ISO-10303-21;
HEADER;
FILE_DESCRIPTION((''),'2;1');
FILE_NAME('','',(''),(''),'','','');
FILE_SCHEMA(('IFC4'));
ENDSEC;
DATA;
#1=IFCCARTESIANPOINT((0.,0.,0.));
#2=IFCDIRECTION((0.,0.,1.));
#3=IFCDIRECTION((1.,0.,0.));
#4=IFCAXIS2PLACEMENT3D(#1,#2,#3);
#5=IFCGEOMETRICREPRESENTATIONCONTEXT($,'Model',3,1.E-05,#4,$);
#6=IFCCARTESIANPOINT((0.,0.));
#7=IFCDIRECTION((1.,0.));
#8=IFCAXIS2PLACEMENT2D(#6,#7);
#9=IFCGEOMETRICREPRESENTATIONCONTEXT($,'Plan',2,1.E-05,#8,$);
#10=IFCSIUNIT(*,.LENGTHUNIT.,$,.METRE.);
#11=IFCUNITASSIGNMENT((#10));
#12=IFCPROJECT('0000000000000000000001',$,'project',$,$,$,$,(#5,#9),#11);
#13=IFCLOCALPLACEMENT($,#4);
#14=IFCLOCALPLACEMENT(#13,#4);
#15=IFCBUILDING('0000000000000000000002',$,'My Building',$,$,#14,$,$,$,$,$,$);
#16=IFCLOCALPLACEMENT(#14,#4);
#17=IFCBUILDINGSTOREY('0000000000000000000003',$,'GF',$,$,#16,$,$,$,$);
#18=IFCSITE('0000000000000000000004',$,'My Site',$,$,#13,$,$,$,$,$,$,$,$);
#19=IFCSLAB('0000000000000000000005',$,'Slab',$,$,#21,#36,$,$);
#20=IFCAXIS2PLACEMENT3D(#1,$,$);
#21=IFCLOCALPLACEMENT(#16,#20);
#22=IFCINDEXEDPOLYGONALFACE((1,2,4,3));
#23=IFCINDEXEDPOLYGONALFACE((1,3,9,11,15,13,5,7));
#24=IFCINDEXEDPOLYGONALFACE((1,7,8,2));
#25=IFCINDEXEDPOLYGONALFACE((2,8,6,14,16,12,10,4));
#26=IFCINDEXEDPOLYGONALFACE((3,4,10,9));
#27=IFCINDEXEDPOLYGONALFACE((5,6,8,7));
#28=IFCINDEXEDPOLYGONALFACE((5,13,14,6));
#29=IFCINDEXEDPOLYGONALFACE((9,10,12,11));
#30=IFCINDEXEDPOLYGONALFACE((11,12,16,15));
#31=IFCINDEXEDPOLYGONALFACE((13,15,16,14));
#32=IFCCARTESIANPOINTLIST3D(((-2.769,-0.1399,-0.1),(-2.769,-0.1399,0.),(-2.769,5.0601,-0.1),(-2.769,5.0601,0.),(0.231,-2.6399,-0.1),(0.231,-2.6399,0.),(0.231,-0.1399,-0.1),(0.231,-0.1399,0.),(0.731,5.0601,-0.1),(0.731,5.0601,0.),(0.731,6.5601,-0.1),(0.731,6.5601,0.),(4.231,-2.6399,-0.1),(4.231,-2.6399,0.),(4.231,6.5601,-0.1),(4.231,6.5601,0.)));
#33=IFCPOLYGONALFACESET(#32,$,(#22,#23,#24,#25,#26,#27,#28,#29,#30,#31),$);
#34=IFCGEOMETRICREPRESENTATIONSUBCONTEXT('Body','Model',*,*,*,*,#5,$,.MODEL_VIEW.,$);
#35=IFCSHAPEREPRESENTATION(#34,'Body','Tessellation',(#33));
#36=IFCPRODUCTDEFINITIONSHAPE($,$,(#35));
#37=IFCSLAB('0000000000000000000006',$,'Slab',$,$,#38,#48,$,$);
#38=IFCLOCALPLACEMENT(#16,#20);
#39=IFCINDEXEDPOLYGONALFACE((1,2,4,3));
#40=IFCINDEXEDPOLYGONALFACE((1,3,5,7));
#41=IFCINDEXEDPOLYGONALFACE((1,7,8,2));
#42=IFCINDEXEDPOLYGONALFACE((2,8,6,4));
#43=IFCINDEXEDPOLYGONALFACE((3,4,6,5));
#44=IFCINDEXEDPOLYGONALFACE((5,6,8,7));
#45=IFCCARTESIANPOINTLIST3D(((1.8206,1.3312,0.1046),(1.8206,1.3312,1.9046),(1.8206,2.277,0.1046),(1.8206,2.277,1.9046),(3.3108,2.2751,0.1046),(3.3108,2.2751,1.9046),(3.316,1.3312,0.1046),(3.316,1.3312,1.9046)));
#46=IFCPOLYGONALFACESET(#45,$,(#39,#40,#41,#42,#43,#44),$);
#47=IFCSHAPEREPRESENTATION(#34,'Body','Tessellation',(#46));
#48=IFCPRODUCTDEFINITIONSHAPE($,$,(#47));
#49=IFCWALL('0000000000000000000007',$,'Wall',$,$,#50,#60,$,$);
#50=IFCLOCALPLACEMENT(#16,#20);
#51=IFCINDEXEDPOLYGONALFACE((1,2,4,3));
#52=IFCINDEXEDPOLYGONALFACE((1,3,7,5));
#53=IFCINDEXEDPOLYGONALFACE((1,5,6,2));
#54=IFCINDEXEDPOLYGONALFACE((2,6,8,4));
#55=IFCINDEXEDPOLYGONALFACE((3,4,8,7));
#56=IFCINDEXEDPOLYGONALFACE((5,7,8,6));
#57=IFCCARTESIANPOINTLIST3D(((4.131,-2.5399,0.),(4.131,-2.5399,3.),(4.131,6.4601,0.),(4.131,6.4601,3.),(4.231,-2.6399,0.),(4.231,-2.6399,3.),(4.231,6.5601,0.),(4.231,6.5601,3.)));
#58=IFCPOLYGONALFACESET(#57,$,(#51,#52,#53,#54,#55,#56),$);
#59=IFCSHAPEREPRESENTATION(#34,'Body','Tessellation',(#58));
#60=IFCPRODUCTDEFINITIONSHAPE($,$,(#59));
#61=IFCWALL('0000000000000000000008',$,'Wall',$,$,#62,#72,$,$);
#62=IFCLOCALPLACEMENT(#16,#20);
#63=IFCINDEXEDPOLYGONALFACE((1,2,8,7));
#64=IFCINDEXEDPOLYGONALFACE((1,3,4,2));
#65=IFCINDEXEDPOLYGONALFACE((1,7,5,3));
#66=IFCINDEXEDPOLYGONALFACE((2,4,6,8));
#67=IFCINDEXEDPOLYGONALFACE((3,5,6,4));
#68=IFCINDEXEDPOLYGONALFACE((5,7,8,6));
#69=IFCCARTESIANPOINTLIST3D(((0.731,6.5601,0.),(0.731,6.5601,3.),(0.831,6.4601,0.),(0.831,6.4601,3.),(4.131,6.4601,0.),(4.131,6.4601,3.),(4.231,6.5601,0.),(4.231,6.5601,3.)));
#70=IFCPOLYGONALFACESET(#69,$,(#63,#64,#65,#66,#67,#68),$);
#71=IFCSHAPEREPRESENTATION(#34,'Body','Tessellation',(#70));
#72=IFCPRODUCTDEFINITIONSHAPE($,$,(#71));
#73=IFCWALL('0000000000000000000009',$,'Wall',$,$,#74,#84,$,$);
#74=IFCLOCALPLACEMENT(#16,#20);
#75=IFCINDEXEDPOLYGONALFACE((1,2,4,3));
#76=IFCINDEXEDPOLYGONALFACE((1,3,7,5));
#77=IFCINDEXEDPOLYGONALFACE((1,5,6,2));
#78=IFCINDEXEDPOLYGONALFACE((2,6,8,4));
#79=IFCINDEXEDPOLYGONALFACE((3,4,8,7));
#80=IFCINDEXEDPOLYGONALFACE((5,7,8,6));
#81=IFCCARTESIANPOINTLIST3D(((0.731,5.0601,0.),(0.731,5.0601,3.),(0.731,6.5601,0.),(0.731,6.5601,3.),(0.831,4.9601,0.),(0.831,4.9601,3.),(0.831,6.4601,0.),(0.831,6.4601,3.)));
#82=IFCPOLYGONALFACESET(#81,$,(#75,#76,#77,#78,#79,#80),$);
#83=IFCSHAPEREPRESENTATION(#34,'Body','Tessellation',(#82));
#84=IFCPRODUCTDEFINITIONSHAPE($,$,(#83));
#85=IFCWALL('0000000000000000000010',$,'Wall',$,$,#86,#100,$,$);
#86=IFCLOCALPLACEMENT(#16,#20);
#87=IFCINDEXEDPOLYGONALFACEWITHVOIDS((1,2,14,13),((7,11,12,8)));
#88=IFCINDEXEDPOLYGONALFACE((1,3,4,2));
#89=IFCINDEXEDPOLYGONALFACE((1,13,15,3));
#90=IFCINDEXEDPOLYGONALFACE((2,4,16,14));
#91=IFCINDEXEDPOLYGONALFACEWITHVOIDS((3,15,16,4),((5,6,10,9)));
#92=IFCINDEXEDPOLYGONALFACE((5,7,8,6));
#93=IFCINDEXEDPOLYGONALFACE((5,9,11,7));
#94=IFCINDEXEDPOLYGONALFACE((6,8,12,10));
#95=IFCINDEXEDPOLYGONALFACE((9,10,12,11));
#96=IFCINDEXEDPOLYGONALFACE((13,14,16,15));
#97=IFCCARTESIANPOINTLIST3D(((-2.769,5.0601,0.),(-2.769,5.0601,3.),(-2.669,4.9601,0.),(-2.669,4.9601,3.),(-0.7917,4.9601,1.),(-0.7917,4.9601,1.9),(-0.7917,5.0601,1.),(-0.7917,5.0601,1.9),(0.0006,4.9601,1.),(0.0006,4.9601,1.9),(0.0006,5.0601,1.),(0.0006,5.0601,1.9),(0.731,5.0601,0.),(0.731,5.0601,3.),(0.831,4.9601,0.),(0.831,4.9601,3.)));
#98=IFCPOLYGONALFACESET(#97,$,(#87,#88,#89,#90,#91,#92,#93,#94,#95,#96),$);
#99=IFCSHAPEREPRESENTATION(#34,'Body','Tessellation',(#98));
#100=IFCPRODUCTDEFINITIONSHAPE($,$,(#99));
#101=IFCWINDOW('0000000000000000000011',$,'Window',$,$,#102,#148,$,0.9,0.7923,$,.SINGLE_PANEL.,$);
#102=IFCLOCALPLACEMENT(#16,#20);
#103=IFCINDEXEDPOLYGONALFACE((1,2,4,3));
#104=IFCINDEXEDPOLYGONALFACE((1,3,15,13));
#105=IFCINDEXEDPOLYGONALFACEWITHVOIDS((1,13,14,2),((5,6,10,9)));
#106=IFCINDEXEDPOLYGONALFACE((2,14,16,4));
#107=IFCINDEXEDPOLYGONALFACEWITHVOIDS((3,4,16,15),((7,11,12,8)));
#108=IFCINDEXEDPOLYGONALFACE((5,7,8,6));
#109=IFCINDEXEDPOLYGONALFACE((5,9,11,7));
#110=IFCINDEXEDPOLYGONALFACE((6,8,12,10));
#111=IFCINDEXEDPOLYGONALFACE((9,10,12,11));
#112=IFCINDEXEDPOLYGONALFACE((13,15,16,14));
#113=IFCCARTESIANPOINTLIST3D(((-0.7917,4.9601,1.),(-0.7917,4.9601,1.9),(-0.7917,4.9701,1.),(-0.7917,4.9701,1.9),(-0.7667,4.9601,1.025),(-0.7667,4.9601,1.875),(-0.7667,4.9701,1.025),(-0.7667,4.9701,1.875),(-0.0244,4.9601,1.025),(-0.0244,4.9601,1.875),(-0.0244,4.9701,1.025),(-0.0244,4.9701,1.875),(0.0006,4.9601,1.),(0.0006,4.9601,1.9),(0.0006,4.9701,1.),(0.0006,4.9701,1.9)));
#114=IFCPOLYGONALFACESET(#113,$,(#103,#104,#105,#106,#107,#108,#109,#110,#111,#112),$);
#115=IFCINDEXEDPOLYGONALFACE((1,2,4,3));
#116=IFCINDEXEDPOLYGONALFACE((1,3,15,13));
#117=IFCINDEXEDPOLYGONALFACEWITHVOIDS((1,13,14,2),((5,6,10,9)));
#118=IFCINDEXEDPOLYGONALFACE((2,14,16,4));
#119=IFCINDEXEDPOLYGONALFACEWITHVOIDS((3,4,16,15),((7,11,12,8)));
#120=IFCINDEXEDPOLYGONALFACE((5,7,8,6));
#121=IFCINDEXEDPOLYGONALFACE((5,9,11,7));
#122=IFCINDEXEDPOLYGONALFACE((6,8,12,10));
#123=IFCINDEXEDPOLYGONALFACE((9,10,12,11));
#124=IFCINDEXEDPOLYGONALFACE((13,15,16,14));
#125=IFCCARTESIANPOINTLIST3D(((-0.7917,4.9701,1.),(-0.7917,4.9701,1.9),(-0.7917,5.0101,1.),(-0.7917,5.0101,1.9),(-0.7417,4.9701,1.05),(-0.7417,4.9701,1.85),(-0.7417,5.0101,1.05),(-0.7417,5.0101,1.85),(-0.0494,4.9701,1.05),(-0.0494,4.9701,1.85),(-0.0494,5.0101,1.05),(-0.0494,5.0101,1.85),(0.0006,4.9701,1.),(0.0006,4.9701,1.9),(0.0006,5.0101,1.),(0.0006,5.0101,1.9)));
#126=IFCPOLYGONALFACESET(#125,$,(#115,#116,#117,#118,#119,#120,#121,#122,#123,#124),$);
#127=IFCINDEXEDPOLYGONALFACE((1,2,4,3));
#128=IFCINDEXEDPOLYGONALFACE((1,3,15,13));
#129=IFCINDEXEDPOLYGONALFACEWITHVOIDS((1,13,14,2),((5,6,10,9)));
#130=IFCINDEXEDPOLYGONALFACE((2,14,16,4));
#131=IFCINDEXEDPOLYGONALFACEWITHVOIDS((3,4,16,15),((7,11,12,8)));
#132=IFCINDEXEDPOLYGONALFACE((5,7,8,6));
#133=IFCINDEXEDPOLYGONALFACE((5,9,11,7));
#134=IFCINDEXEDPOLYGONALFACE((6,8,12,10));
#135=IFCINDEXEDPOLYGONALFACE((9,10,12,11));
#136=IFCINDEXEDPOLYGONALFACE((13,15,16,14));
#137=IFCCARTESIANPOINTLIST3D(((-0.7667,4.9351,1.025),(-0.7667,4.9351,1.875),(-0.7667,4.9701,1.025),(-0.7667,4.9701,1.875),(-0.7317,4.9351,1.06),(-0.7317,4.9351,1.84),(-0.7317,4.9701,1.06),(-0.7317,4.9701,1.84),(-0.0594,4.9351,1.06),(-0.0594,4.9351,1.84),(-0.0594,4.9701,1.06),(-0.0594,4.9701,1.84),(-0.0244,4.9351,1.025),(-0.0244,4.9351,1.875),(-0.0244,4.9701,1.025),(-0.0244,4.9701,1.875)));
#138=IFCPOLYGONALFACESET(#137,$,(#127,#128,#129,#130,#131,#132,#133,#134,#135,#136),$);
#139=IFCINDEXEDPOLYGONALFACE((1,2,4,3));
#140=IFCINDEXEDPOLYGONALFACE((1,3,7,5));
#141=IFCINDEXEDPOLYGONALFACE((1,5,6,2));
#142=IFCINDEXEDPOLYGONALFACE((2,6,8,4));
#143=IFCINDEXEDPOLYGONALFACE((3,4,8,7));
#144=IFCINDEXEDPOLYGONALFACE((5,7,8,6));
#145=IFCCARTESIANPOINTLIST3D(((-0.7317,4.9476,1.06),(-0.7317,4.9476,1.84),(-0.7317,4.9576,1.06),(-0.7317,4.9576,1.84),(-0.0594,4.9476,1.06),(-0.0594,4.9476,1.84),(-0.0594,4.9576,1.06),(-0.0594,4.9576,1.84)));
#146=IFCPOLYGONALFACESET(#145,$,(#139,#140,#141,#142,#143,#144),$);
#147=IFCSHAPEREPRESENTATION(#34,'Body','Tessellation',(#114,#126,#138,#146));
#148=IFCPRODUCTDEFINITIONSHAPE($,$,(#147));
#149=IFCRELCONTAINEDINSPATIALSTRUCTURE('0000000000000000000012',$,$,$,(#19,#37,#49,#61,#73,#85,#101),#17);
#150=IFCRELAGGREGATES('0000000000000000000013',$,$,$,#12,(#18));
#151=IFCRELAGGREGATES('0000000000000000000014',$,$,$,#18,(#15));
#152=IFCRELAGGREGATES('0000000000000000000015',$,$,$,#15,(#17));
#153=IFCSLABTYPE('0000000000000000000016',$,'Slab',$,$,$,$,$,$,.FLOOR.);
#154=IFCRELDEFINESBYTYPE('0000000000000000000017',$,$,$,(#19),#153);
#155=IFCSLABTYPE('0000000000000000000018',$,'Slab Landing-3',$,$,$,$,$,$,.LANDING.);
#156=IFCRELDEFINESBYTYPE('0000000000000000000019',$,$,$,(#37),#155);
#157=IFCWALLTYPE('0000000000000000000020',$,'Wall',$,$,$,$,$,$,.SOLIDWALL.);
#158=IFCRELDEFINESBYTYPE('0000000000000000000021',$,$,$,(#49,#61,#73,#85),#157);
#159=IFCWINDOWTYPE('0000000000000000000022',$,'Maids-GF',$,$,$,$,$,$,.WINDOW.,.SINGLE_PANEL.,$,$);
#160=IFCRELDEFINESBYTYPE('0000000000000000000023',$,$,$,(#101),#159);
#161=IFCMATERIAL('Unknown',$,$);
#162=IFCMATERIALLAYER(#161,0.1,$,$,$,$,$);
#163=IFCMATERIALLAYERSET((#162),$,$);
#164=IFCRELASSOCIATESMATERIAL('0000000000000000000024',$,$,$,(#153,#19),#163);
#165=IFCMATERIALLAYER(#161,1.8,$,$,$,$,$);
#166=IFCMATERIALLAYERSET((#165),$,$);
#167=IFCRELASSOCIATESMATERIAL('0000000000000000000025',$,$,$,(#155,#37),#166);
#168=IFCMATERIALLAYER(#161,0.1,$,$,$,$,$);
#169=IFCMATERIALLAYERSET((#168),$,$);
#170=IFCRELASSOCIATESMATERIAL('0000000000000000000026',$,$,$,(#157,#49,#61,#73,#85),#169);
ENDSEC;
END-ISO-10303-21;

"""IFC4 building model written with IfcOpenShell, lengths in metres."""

from ifc_helpers import new_model, entity, si_unit, frame, origin_with_axes, origin_2d_with_axis, place, context, subcontext, project, spatial, line, indexed_curve, outline, extrude, shape, source, transform, mapped, material, layer, layer_set, layer_usage, type_object, type_shapes, element, fill, save


model = new_model("IFC4")

# Units and contexts
model_context = context("Model", 3, precision=1e-05, world=origin_with_axes())
plan_context = context("Plan", 2, precision=1e-05, world=origin_2d_with_axis())
body_context_1 = subcontext(model_context, "Body", "Model", "MODEL_VIEW")
body_context_2 = subcontext(plan_context, "Body", "Plan", "PLAN_VIEW")
ifc_project = project(units=[si_unit("LENGTHUNIT", "METRE")], contexts=[model_context, plan_context])

# Site, building, storey
site_placement = place(None, origin_with_axes())
site = spatial("IfcSite", under=ifc_project, at=site_placement, Name="My Site")
building_placement = place(site_placement, origin_with_axes())
building = spatial("IfcBuilding", under=site, at=building_placement, Name="My Building")
storey_placement = place(building_placement, origin_with_axes())
storey = spatial("IfcBuildingStorey", under=building, at=storey_placement, Name="GF")

# Slabs
ifc_material_1 = material(Name="Unknown")
ifc_layer_1 = layer(ifc_material_1, 0.1)
ifc_layer_set_1 = layer_set([ifc_layer_1])
ifc_layer_usage_1 = layer_usage(ifc_layer_set_1, "AXIS3", "POSITIVE", -0.1)
slab_type_1 = type_object("IfcSlabType", Name="Slab", PredefinedType="FLOOR", material=ifc_layer_set_1)
slab_1_placement = place(storey_placement, frame((4.231, 6.5601, 0.0), z_axis=(0.0, 0.0, 1.0), x_axis=(1.0, 0.0, 0.0)))
element("IfcSlab", 1, at=slab_1_placement, inside=storey, type_object=slab_type_1, material=ifc_layer_usage_1, Name="Slab", context=body_context_1, shape_type="SweptSolid", body=[
    extrude(outline(indexed_curve([(0.0, 0.0), (-3.5, 0.0), (-3.5, -1.5), (-7.0, -1.5), (-7.0, -6.7), (-4.0, -6.7), (-4.0, -9.2), (0.0, -9.2), (0.0, 0.0)])), frame((0.0, 0.0, -0.1), z_axis=(0.0, 0.0, 1.0), x_axis=(1.0, 0.0, 0.0)), (0.0, 0.0, 1.0), 0.1),
])
ifc_layer_2 = layer(ifc_material_1, 1.8)
ifc_layer_set_2 = layer_set([ifc_layer_2])
ifc_layer_usage_2 = layer_usage(ifc_layer_set_2, "AXIS3", "POSITIVE", -1.8)
slab_type_2 = type_object("IfcSlabType", Name="Slab Landing-3", PredefinedType="LANDING", material=ifc_layer_set_2)
slab_2_placement = place(storey_placement, frame((3.3108, 2.2751, 1.9046), z_axis=(0.0, 0.0, 1.0), x_axis=(1.0, 0.0, 0.0)))
element("IfcSlab", 2, at=slab_2_placement, inside=storey, type_object=slab_type_2, material=ifc_layer_usage_2, Name="Slab", context=body_context_1, shape_type="SweptSolid", body=[
    extrude(outline(indexed_curve([(0.0, 0.0), (0.0053, -0.9439), (-1.4901, -0.9439), (-1.4902, 0.0019), (0.0, 0.0)])), frame((0.0, 0.0, -1.8), z_axis=(0.0, 0.0, 1.0), x_axis=(1.0, 0.0, 0.0)), (0.0, 0.0, 1.0), 1.8),
])

# Shared definitions
ifc_layer_3 = layer(ifc_material_1, 0.1)
ifc_layer_set_3 = layer_set([ifc_layer_3])
wall_type = type_object("IfcWallType", Name="Wall", PredefinedType="SOLIDWALL", material=ifc_layer_set_3)

# Walls
ifc_layer_usage_3 = layer_usage(ifc_layer_set_3, "AXIS2", "POSITIVE", 0.0)
wall_1_placement = place(storey_placement, frame((4.231, -2.6399, 0.0), z_axis=(0.0, 0.0, 1.0), x_axis=(0.0, 1.0, 0.0)))
element("IfcWall", 3, at=wall_1_placement, inside=storey, type_object=wall_type, material=ifc_layer_usage_3, Name="Wall", context=body_context_1, shape_type="SweptSolid", body=[
    extrude(outline(indexed_curve([(0.0, 0.0), (0.1, 0.1), (9.1, 0.1), (9.2, 0.0)], segments=[line(1, 2, 3, 4, 1)])), origin_with_axes(), (0.0, 0.0, 1.0), 3.0),
])
ifc_layer_usage_4 = layer_usage(ifc_layer_set_3, "AXIS2", "POSITIVE", 0.0)
wall_2_placement = place(storey_placement, frame((4.231, 6.5601, 0.0), z_axis=(0.0, 0.0, 1.0), x_axis=(-1.0, 0.0, 0.0)))
element("IfcWall", 4, at=wall_2_placement, inside=storey, type_object=wall_type, material=ifc_layer_usage_4, Name="Wall", context=body_context_1, shape_type="SweptSolid", body=[
    extrude(outline(indexed_curve([(0.0, 0.0), (0.1, 0.1), (3.4, 0.1), (3.5, 0.0)], segments=[line(1, 2, 3, 4, 1)])), origin_with_axes(), (0.0, 0.0, 1.0), 3.0),
])
ifc_layer_usage_5 = layer_usage(ifc_layer_set_3, "AXIS2", "POSITIVE", 0.0)
wall_3_placement = place(storey_placement, frame((0.731, 6.5601, 0.0), z_axis=(0.0, 0.0, 1.0), x_axis=(0.0, -1.0, 0.0)))
element("IfcWall", 5, at=wall_3_placement, inside=storey, type_object=wall_type, material=ifc_layer_usage_5, Name="Wall", context=body_context_1, shape_type="SweptSolid", body=[
    extrude(outline(indexed_curve([(0.0, 0.0), (0.1, 0.1), (1.6, 0.1), (1.5, 0.0)], segments=[line(1, 2, 3, 4, 1)])), origin_with_axes(), (0.0, 0.0, 1.0), 3.0),
])

# Wall, opening, window
ifc_layer_usage_6 = layer_usage(ifc_layer_set_3, "AXIS2", "POSITIVE", 0.0)
wall_4_placement = place(storey_placement, frame((0.731, 5.0601, 0.0), z_axis=(0.0, 0.0, 1.0), x_axis=(-1.0, 0.0, 0.0)))
wall_4 = element("IfcWall", 6, at=wall_4_placement, inside=storey, type_object=wall_type, material=ifc_layer_usage_6, Name="Wall", context=body_context_1, shape_type="SweptSolid", body=[
    extrude(outline(indexed_curve([(0.0, 0.0), (-0.1, 0.1), (3.4, 0.1), (3.5, 0.0)], segments=[line(1, 2, 3, 4, 1)])), origin_with_axes(), (0.0, 0.0, 1.0), 3.0),
])
shared_shape_1 = source(origin_with_axes(), body_context_1, "Body", "SweptSolid", [
    extrude(outline(indexed_curve([(0.0, 0.0), (0.7923, 0.0), (0.7923, 0.9), (0.0, 0.9)], segments=[line(1, 2, 3, 4, 1)])), frame((0.0, -0.6, 0.0), z_axis=(0.0, -1.0, 0.0), x_axis=(1.0, 0.0, 0.0)), (0.0, 0.0, -1.0), 1.2),
])
opening_1_placement = place(wall_4_placement, frame((0.7304, 0.0, 1.0), z_axis=(0.0, 0.0, 1.0), x_axis=(1.0, 0.0, 0.0)))
opening_1 = element("IfcOpeningElement", 7, at=opening_1_placement, cuts=wall_4, PredefinedType="OPENING", context=body_context_1, shape_type="MappedRepresentation", body=[
    mapped(shared_shape_1, transform((0.0, 0.0, 0.0), x_axis=(1.0, 0.0, 0.0), y_axis=(0.0, 1.0, 0.0), z_axis=(0.0, 0.0, 1.0), scale=1.0)),
])
window_type_1 = type_object("IfcWindowType", Name="Maids-GF", PartitioningType="SINGLE_PANEL", PredefinedType="WINDOW")
shared_shape_2 = source(origin_with_axes(), body_context_1, "Body", "SweptSolid", [
    extrude(outline(indexed_curve([(0.0, 0.0), (0.7923, 0.0), (0.7923, 0.9), (0.0, 0.9)], segments=[line(1, 2, 3, 4, 1)]), holes=[indexed_curve([(0.025, 0.025), (0.7673, 0.025), (0.7673, 0.875), (0.025, 0.875)], segments=[line(1, 2, 3, 4, 1)])]), frame((0.0, 0.09, 0.0), z_axis=(0.0, -1.0, 0.0), x_axis=(1.0, 0.0, 0.0)), (0.0, 0.0, -1.0), 0.01),
    extrude(outline(indexed_curve([(0.0, 0.0), (0.7923, 0.0), (0.7923, 0.9), (0.0, 0.9)], segments=[line(1, 2, 3, 4, 1)]), holes=[indexed_curve([(0.05, 0.05), (0.7423, 0.05), (0.7423, 0.85), (0.05, 0.85)], segments=[line(1, 2, 3, 4, 1)])]), frame((0.0, 0.05, 0.0), z_axis=(0.0, -1.0, 0.0), x_axis=(1.0, 0.0, 0.0)), (0.0, 0.0, -1.0), 0.04),
    extrude(outline(indexed_curve([(0.0, 0.0), (0.7423, 0.0), (0.7423, 0.85), (0.0, 0.85)], segments=[line(1, 2, 3, 4, 1)]), holes=[indexed_curve([(0.035, 0.035), (0.7073, 0.035), (0.7073, 0.815), (0.035, 0.815)], segments=[line(1, 2, 3, 4, 1)])]), frame((0.025, 0.09, 0.025), z_axis=(0.0, -1.0, 0.0), x_axis=(1.0, 0.0, 0.0)), (0.0, 0.0, -1.0), 0.035),
    extrude(outline(indexed_curve([(0.035, 0.035), (0.7073, 0.035), (0.7073, 0.815), (0.035, 0.815)], segments=[line(1, 2, 3, 4, 1)])), frame((0.025, 0.1025, 0.025), z_axis=(0.0, -1.0, 0.0), x_axis=(1.0, 0.0, 0.0)), (0.0, 0.0, -1.0), 0.01),
])
shared_shape_3 = source(origin_with_axes(), body_context_2, "Body", "Curve2D", [
    entity("IfcIndexedPolyCurve", entity("IfcCartesianPointList2D", [[0.05, 0.05], [0.7423, 0.05]])),
    entity("IfcIndexedPolyCurve", entity("IfcCartesianPointList2D", [[0.0, 0.1], [0.025, 0.1], [0.025, 0.09], [0.05, 0.09], [0.05, 0.05], [0.0, 0.05]]), [entity("IfcLineIndex", [1, 2, 3, 4, 5, 6, 1])]),
    entity("IfcIndexedPolyCurve", entity("IfcCartesianPointList2D", [[0.7923, 0.1], [0.7673, 0.1], [0.7673, 0.09], [0.7423, 0.09], [0.7423, 0.05], [0.7923, 0.05]]), [entity("IfcLineIndex", [1, 2, 3, 4, 5, 6, 1])]),
    entity("IfcIndexedPolyCurve", entity("IfcCartesianPointList2D", [[0.025, 0.09], [0.06, 0.09], [0.06, 0.125], [0.025, 0.125]]), [entity("IfcLineIndex", [1, 2, 3, 4, 1])]),
    entity("IfcIndexedPolyCurve", entity("IfcCartesianPointList2D", [[0.7673, 0.09], [0.7323, 0.09], [0.7323, 0.125], [0.7673, 0.125]]), [entity("IfcLineIndex", [1, 2, 3, 4, 1])]),
    entity("IfcIndexedPolyCurve", entity("IfcCartesianPointList2D", [[0.06, 0.09], [0.7323, 0.09]])),
    entity("IfcIndexedPolyCurve", entity("IfcCartesianPointList2D", [[0.06, 0.125], [0.7323, 0.125]])),
    entity("IfcIndexedPolyCurve", entity("IfcCartesianPointList2D", [[0.06, 0.1075], [0.7323, 0.1075]])),
])
type_shapes(window_type_1, [shared_shape_2, shared_shape_3])
window_1_placement = place(opening_1_placement, frame((0.0, 0.0, 0.0), z_axis=(0.0, 0.0, 1.0), x_axis=(1.0, 0.0, 0.0)))
window_1 = element("IfcWindow", 8, at=window_1_placement, inside=storey, type_object=window_type_1, Name="Window", OverallHeight=0.9, OverallWidth=0.7923, PartitioningType="SINGLE_PANEL", shapes=[
    shape(body_context_1, "Body", "MappedRepresentation", [mapped(shared_shape_2, transform((0.0, 0.0, 0.0), x_axis=(1.0, 0.0, 0.0), y_axis=(0.0, 1.0, 0.0), z_axis=(0.0, 0.0, 1.0), scale=1.0))]),
    shape(body_context_2, "Body", "MappedRepresentation", [mapped(shared_shape_3, transform((0.0, 0.0, 0.0), x_axis=(1.0, 0.0, 0.0), y_axis=(0.0, 1.0, 0.0), z_axis=(0.0, 0.0, 1.0), scale=1.0))]),
])
fill(opening_1, window_1)

save(model, "model.ifc")
